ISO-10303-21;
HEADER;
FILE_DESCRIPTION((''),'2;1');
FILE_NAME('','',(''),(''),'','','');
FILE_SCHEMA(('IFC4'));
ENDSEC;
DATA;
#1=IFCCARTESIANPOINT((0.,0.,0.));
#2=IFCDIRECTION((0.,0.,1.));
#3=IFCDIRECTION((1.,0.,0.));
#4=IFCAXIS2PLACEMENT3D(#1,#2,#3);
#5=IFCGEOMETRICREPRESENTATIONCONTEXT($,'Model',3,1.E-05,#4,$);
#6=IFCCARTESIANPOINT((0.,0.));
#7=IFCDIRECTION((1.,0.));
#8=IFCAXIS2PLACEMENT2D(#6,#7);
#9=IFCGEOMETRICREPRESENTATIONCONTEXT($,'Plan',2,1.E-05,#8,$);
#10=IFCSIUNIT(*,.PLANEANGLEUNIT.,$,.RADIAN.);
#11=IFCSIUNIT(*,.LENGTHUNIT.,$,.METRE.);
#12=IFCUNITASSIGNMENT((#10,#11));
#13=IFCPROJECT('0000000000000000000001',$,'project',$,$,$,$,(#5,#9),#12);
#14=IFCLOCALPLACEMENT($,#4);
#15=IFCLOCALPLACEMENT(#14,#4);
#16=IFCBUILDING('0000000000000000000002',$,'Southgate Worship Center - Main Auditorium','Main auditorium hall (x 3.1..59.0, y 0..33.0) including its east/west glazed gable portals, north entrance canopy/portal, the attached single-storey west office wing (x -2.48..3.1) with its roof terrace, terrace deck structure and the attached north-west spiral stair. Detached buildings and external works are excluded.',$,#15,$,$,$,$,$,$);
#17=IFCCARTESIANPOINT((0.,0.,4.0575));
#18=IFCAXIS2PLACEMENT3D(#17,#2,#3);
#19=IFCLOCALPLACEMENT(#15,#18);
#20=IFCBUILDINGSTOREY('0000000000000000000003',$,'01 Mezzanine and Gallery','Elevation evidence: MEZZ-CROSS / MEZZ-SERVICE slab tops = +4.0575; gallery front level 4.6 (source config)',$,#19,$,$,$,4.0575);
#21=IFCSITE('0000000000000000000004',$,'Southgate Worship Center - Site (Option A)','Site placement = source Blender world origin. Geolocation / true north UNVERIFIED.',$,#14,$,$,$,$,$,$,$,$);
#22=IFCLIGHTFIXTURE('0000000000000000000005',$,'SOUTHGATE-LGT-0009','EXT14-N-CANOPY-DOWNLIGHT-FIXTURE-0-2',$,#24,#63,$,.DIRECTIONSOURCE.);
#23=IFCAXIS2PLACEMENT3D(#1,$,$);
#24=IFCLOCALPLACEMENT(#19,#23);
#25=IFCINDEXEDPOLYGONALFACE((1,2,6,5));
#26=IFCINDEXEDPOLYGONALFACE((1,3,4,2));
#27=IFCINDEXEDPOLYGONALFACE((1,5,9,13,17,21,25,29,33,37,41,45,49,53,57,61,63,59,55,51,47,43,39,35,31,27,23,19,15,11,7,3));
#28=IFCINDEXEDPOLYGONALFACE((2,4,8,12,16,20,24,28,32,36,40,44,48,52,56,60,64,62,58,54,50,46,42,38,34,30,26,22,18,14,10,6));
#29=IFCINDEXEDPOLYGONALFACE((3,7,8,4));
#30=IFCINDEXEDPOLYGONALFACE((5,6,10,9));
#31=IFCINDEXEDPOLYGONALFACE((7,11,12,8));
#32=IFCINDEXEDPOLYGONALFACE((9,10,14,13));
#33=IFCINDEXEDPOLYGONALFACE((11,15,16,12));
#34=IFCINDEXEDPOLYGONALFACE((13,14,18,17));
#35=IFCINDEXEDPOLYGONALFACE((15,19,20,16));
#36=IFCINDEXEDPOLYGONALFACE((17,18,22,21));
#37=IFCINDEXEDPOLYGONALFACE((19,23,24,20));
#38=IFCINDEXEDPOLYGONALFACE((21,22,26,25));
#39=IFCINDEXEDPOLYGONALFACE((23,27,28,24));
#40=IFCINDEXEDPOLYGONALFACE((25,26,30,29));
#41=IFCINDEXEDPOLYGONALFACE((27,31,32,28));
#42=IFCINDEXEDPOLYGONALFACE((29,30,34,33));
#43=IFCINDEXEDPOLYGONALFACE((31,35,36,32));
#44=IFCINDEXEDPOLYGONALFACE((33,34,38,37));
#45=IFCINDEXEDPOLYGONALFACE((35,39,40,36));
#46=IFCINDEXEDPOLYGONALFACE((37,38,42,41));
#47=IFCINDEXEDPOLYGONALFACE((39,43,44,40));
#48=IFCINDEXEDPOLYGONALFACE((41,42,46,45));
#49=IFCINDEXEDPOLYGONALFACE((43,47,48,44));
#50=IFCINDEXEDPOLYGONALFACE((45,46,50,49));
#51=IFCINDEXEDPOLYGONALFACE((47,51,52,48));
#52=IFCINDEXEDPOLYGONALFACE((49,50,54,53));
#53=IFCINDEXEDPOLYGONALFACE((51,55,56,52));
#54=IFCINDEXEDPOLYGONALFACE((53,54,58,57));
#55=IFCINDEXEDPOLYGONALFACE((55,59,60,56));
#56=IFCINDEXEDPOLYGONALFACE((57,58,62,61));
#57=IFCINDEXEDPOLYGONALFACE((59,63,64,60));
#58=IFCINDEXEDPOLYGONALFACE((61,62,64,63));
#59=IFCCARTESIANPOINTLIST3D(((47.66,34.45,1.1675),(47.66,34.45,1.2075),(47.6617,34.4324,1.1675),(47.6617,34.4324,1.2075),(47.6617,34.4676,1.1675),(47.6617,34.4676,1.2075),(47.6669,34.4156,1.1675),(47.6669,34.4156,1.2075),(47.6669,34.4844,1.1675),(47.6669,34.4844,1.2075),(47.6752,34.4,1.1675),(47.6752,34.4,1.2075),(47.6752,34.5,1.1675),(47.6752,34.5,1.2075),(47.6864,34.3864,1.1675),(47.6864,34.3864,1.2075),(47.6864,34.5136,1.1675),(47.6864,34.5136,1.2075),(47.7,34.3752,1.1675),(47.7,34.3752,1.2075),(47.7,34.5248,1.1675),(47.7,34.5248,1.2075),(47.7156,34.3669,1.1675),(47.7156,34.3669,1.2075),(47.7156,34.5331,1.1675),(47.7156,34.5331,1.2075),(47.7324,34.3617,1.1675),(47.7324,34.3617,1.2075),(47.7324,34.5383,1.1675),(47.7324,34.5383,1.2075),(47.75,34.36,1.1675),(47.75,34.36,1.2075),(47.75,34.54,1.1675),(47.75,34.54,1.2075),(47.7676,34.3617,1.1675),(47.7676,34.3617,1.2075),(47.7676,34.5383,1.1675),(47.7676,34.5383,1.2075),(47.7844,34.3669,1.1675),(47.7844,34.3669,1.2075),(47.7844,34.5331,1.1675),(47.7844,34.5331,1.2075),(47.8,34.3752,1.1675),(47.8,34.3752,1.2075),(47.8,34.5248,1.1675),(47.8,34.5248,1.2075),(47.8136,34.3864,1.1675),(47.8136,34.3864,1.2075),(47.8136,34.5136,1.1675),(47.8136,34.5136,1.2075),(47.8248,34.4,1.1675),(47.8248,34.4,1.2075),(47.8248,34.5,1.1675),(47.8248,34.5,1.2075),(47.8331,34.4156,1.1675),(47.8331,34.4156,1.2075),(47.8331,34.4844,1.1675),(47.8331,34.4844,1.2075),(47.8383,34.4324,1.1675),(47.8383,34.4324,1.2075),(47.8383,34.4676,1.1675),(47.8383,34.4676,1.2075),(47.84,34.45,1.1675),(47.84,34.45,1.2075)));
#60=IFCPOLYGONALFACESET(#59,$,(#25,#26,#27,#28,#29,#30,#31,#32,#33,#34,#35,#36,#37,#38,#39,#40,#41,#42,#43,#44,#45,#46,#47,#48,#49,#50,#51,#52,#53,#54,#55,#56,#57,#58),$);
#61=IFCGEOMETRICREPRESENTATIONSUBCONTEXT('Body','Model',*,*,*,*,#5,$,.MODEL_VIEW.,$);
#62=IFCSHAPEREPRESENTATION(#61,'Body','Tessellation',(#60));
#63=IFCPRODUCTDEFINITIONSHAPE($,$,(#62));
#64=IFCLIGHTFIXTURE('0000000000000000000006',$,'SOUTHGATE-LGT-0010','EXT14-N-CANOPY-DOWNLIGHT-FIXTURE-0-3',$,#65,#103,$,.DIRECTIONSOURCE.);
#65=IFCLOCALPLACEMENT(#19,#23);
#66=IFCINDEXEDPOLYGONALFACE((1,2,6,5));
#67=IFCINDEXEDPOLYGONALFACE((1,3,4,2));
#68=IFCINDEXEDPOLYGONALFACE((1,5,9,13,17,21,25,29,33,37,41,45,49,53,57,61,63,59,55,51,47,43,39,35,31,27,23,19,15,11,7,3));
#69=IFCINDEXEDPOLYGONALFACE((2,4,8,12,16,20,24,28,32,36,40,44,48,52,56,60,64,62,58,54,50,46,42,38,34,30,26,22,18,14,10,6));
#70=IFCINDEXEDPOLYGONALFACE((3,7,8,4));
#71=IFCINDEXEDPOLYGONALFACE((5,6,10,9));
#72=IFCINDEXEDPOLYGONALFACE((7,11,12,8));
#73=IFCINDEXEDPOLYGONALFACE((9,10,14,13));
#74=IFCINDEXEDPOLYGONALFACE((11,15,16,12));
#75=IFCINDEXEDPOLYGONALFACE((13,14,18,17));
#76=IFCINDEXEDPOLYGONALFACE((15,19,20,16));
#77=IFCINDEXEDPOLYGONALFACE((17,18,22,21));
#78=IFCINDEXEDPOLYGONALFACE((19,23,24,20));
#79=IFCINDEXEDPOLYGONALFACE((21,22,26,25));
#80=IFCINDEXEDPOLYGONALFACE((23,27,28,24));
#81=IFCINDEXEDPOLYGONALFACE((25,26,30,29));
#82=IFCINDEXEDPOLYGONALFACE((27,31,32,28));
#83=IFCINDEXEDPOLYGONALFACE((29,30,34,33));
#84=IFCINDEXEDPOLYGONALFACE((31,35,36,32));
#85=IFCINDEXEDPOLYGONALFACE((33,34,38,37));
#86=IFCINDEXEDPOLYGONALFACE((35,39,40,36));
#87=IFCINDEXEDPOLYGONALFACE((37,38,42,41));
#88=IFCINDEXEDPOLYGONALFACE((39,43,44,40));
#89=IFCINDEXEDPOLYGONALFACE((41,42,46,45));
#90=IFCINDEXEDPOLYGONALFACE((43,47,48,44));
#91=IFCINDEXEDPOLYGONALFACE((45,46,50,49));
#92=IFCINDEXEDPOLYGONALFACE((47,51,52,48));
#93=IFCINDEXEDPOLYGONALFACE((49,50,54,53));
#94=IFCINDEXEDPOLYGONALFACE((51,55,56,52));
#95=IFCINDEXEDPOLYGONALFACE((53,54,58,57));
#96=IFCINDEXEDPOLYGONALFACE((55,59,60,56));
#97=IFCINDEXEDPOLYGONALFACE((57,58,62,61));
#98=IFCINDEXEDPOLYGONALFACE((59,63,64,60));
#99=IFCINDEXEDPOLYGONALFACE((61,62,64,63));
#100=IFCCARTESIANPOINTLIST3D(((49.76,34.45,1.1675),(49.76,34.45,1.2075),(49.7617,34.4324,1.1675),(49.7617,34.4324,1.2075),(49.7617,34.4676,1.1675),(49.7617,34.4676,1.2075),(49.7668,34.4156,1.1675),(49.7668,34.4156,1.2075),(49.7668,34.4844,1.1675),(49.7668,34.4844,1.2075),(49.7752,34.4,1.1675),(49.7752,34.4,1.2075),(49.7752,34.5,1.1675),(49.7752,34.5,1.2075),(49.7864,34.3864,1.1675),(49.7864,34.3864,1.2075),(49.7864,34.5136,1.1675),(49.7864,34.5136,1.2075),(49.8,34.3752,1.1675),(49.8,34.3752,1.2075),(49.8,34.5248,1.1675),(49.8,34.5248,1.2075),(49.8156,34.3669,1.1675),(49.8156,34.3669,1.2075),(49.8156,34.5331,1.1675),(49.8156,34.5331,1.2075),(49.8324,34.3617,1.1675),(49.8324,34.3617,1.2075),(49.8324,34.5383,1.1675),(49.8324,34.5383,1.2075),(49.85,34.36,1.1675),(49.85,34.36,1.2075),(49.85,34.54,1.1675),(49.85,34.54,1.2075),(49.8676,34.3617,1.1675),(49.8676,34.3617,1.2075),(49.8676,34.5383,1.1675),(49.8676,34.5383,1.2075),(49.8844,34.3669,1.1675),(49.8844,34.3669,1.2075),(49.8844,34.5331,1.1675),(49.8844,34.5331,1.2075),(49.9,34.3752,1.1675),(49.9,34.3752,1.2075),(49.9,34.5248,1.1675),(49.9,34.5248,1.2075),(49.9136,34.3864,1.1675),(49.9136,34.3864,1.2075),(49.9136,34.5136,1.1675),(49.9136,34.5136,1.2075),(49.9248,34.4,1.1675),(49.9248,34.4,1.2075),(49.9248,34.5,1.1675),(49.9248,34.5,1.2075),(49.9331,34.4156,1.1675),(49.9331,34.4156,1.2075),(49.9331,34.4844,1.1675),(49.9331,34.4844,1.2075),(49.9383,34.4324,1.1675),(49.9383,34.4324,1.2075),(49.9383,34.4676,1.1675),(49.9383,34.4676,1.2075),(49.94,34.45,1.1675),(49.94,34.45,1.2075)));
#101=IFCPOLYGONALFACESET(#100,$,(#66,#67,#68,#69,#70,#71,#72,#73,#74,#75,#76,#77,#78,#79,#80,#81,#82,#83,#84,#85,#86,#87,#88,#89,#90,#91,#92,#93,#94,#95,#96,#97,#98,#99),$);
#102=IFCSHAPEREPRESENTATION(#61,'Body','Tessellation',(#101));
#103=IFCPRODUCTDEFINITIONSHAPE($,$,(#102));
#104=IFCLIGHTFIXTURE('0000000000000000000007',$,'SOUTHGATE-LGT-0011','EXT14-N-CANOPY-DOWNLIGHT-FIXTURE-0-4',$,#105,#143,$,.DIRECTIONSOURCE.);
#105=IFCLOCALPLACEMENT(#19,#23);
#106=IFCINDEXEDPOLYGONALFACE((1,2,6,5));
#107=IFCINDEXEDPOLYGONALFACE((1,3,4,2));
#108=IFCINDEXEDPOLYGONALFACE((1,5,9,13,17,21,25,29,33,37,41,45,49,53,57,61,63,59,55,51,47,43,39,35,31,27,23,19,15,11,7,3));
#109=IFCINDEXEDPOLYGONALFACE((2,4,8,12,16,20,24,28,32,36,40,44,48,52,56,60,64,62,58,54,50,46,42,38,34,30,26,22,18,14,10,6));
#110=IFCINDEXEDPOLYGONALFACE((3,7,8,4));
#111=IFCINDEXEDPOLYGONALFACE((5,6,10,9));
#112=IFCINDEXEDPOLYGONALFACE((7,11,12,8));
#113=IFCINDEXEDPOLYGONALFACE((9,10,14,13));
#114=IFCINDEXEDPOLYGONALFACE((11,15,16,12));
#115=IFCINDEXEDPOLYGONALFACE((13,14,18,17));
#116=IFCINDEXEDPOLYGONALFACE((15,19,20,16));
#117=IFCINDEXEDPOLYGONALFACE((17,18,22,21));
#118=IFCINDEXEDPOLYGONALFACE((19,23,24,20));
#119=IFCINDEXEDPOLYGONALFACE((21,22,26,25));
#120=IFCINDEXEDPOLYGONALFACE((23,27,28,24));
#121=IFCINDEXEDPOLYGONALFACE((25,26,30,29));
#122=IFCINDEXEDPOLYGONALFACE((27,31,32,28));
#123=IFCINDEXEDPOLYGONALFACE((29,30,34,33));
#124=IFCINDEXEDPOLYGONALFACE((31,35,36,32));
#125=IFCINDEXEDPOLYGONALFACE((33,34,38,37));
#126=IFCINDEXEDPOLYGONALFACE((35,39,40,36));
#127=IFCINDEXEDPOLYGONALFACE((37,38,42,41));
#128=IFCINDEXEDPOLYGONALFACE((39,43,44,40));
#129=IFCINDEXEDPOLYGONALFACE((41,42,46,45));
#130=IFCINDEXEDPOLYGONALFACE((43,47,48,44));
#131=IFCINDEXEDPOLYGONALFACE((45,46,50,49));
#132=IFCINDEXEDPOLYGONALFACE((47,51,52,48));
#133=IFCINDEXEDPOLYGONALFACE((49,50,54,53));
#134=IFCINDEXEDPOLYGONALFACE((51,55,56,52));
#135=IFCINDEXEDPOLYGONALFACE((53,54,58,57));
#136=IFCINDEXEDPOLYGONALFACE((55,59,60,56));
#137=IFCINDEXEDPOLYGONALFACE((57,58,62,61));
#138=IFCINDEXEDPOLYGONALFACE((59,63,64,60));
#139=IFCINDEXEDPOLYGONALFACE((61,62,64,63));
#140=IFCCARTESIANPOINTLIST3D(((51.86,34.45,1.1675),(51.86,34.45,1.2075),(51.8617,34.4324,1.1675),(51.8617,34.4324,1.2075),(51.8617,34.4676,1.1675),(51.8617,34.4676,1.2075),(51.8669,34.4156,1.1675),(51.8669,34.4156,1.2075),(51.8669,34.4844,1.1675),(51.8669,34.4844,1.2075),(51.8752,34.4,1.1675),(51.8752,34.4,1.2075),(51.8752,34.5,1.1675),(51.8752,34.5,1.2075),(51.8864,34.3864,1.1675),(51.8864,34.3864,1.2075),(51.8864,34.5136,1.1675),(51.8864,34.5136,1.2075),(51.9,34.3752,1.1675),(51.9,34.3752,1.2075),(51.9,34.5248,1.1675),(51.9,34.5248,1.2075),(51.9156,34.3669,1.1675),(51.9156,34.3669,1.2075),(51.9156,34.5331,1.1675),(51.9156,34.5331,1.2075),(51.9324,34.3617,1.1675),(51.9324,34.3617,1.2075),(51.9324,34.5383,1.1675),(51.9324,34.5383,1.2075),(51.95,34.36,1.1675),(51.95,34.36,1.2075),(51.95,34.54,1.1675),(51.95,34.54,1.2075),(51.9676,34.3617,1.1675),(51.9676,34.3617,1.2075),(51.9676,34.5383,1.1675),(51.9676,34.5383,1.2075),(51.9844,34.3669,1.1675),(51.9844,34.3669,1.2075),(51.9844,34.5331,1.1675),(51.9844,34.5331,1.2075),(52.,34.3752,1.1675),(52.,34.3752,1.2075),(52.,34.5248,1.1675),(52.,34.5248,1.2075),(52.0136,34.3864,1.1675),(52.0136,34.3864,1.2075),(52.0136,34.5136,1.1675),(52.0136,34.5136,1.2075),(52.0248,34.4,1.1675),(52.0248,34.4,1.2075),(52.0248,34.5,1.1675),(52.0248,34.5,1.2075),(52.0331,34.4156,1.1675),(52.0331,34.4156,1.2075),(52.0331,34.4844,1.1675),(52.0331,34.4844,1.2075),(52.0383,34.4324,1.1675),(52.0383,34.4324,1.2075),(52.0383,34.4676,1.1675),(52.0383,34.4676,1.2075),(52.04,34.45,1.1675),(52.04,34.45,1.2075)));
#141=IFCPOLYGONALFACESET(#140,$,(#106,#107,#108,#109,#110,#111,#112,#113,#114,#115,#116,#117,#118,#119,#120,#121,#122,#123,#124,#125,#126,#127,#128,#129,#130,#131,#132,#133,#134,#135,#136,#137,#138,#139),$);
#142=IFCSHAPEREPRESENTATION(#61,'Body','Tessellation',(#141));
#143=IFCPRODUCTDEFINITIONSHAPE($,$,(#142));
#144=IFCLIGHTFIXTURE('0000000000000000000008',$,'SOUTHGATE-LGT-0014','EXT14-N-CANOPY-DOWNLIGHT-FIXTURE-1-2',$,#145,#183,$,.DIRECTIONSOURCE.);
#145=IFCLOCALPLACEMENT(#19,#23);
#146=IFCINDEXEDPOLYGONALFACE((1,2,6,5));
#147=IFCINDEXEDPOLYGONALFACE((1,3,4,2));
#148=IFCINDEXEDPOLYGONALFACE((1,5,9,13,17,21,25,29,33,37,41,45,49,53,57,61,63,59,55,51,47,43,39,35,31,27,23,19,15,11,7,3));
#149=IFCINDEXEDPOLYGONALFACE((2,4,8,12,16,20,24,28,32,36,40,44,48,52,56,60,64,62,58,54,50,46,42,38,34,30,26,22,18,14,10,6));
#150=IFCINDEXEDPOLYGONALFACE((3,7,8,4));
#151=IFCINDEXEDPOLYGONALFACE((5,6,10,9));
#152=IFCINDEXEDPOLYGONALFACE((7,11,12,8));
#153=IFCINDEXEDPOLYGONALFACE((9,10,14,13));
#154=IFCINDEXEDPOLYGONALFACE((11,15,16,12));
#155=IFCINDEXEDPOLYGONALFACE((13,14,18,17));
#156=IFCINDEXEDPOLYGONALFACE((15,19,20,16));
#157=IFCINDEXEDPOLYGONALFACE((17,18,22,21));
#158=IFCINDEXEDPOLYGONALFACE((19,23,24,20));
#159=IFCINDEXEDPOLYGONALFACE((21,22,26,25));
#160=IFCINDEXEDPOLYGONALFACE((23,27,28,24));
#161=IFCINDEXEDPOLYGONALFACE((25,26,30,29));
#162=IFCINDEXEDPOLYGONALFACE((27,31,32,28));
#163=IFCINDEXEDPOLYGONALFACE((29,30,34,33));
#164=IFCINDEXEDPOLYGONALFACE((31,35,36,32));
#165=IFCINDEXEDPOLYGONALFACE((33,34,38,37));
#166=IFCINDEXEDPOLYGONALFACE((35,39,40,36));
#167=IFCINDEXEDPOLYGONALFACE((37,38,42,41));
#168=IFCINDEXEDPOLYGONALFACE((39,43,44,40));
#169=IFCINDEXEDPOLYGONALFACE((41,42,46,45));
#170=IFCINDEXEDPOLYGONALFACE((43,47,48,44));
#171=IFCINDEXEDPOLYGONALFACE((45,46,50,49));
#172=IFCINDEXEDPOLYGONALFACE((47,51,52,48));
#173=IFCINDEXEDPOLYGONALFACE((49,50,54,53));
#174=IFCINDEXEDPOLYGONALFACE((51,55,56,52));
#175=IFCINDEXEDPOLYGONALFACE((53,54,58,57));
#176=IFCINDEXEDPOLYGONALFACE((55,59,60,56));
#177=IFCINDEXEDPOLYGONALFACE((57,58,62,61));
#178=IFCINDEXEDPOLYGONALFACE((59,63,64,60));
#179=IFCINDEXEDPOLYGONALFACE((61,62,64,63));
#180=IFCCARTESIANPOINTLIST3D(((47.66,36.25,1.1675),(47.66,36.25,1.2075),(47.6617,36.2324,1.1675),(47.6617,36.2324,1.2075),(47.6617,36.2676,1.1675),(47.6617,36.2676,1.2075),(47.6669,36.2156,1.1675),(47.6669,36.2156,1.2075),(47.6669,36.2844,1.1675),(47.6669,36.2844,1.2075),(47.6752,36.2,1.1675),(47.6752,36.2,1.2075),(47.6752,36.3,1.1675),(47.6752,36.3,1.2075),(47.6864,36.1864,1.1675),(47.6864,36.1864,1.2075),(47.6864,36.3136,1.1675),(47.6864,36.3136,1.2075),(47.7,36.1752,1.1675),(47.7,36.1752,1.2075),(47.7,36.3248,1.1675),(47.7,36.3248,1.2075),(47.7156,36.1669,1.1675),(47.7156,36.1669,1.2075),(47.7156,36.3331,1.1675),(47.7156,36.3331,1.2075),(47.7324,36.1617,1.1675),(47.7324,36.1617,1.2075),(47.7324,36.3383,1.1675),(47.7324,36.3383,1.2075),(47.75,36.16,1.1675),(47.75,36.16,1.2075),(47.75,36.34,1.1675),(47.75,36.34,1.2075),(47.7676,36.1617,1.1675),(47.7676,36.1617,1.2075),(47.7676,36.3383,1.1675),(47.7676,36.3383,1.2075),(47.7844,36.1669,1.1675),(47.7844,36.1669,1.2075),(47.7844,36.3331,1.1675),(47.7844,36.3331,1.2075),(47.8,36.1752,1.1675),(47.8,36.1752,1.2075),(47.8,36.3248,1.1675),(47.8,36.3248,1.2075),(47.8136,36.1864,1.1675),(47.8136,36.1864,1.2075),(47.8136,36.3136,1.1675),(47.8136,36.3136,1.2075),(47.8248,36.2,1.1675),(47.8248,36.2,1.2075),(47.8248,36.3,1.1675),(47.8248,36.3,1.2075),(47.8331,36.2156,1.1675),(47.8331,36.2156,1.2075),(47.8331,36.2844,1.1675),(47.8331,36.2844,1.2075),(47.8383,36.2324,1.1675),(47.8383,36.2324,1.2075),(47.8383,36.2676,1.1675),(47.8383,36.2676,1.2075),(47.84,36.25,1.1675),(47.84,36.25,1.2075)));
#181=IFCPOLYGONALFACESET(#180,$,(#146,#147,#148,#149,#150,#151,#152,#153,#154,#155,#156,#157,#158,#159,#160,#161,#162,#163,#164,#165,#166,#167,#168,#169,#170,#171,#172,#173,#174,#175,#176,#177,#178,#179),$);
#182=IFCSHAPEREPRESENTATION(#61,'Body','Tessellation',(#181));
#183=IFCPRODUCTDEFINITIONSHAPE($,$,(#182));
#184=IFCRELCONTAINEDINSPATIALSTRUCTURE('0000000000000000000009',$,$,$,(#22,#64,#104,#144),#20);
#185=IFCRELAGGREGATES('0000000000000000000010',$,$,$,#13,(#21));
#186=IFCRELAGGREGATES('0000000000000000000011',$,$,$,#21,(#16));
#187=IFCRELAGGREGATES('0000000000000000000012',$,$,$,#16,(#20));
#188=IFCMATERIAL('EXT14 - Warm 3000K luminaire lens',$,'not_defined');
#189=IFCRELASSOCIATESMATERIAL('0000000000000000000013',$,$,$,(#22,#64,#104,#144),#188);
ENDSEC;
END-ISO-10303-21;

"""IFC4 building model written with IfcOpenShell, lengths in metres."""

from ifc_helpers import new_model, si_unit, frame, origin_with_axes, origin_2d_with_axis, place, context, subcontext, project, spatial, indexed_curve, outline, extrude, material, element, save


model = new_model("IFC4")

# Units and contexts
model_context = context("Model", 3, precision=1e-05, world=origin_with_axes())
plan_context = context("Plan", 2, precision=1e-05, world=origin_2d_with_axis())
body_context = subcontext(model_context, "Body", "Model", "MODEL_VIEW")
ifc_project = project(units=[si_unit("PLANEANGLEUNIT", "RADIAN"), si_unit("LENGTHUNIT", "METRE")], contexts=[model_context, plan_context])

# Site, building, storey
site_placement = place(None, origin_with_axes())
site = spatial("IfcSite", under=ifc_project, at=site_placement, Name="Southgate Worship Center - Site (Option A)", Description="Site placement = source Blender world origin. Geolocation / true north UNVERIFIED.")
building_placement = place(site_placement, origin_with_axes())
building = spatial("IfcBuilding", under=site, at=building_placement, Name="Southgate Worship Center - Main Auditorium", Description="Main auditorium hall (x 3.1..59.0, y 0..33.0) including its east/west glazed gable portals, north entrance canopy/portal, the attached single-storey west office wing (x -2.48..3.1) with its roof terrace, terrace deck structure and the attached north-west spiral stair. Detached buildings and external works are excluded.")
storey_placement = place(building_placement, frame((0.0, 0.0, 4.0575), z_axis=(0.0, 0.0, 1.0), x_axis=(1.0, 0.0, 0.0)))
storey = spatial("IfcBuildingStorey", under=building, at=storey_placement, Name="01 Mezzanine and Gallery", Description="Elevation evidence: MEZZ-CROSS / MEZZ-SERVICE slab tops = +4.0575; gallery front level 4.6 (source config)", Elevation=4.0575)

# Light fixtures
ifc_material_1 = material(Name="EXT14 - Warm 3000K luminaire lens", Category="not_defined")
light_fixture_1_placement = place(storey_placement, frame((47.66, 34.36, 1.1675), z_axis=(0.0, 0.0, 1.0), x_axis=(1.0, 0.0, 0.0)))
element("IfcLightFixture", 1, at=light_fixture_1_placement, inside=storey, material=ifc_material_1, Name="SOUTHGATE-LGT-0009", Description="EXT14-N-CANOPY-DOWNLIGHT-FIXTURE-0-2", PredefinedType="DIRECTIONSOURCE", context=body_context, shape_type="SweptSolid", body=[
    extrude(outline(indexed_curve([(0.0, 0.0), (-0.0083, -0.0156), (-0.0134, -0.0324), (-0.0152, -0.05), (-0.0134, -0.0676), (-0.0083, -0.0844), (0.0, -0.1), (0.0112, -0.1136), (0.0248, -0.1248), (0.0404, -0.1332), (0.0573, -0.1383), (0.0748, -0.14), (0.0924, -0.1383), (0.1093, -0.1332), (0.1248, -0.1248), (0.1385, -0.1136), (0.1497, -0.1), (0.158, -0.0844), (0.1631, -0.0676), (0.1648, -0.05), (0.1631, -0.0324), (0.158, -0.0156), (0.1497, 0.0), (0.1385, 0.0136), (0.1248, 0.0248), (0.1093, 0.0331), (0.0924, 0.0383), (0.0748, 0.04), (0.0573, 0.0383), (0.0404, 0.0331), (0.0248, 0.0248), (0.0112, 0.0136), (0.0, 0.0)], self_intersect=False)), frame((0.0152, 0.14, 0.0), z_axis=(0.0, 0.0, 1.0), x_axis=(1.0, 0.0, 0.0)), (0.0, 0.0, 1.0), 0.04),
])
light_fixture_2_placement = place(storey_placement, frame((49.76, 34.36, 1.1675), z_axis=(0.0, 0.0, 1.0), x_axis=(1.0, 0.0, 0.0)))
element("IfcLightFixture", 2, at=light_fixture_2_placement, inside=storey, material=ifc_material_1, Name="SOUTHGATE-LGT-0010", Description="EXT14-N-CANOPY-DOWNLIGHT-FIXTURE-0-3", PredefinedType="DIRECTIONSOURCE", context=body_context, shape_type="SweptSolid", body=[
    extrude(outline(indexed_curve([(0.0, 0.0), (-0.0083, -0.0156), (-0.0134, -0.0324), (-0.0152, -0.05), (-0.0134, -0.0676), (-0.0083, -0.0844), (0.0, -0.1), (0.0112, -0.1136), (0.0248, -0.1248), (0.0404, -0.1332), (0.0573, -0.1383), (0.0748, -0.14), (0.0924, -0.1383), (0.1093, -0.1332), (0.1248, -0.1248), (0.1385, -0.1136), (0.1497, -0.1), (0.158, -0.0844), (0.1631, -0.0676), (0.1648, -0.05), (0.1631, -0.0324), (0.158, -0.0156), (0.1497, 0.0), (0.1385, 0.0136), (0.1248, 0.0248), (0.1093, 0.0331), (0.0924, 0.0383), (0.0748, 0.04), (0.0573, 0.0383), (0.0404, 0.0331), (0.0248, 0.0248), (0.0112, 0.0136), (0.0, 0.0)], self_intersect=False)), frame((0.0152, 0.14, 0.0), z_axis=(0.0, 0.0, 1.0), x_axis=(1.0, 0.0, 0.0)), (0.0, 0.0, 1.0), 0.04),
])
light_fixture_3_placement = place(storey_placement, frame((51.86, 34.36, 1.1675), z_axis=(0.0, 0.0, 1.0), x_axis=(1.0, 0.0, 0.0)))
element("IfcLightFixture", 3, at=light_fixture_3_placement, inside=storey, material=ifc_material_1, Name="SOUTHGATE-LGT-0011", Description="EXT14-N-CANOPY-DOWNLIGHT-FIXTURE-0-4", PredefinedType="DIRECTIONSOURCE", context=body_context, shape_type="SweptSolid", body=[
    extrude(outline(indexed_curve([(0.0, 0.0), (-0.0083, -0.0156), (-0.0134, -0.0324), (-0.0152, -0.05), (-0.0134, -0.0676), (-0.0083, -0.0844), (0.0, -0.1), (0.0112, -0.1136), (0.0248, -0.1248), (0.0404, -0.1332), (0.0573, -0.1383), (0.0748, -0.14), (0.0924, -0.1383), (0.1093, -0.1332), (0.1248, -0.1248), (0.1385, -0.1136), (0.1497, -0.1), (0.158, -0.0844), (0.1631, -0.0676), (0.1648, -0.05), (0.1631, -0.0324), (0.158, -0.0156), (0.1497, 0.0), (0.1385, 0.0136), (0.1248, 0.0248), (0.1093, 0.0331), (0.0924, 0.0383), (0.0748, 0.04), (0.0573, 0.0383), (0.0404, 0.0331), (0.0248, 0.0248), (0.0112, 0.0136), (0.0, 0.0)], self_intersect=False)), frame((0.0152, 0.14, 0.0), z_axis=(0.0, 0.0, 1.0), x_axis=(1.0, 0.0, 0.0)), (0.0, 0.0, 1.0), 0.04),
])
light_fixture_4_placement = place(storey_placement, frame((47.66, 36.16, 1.1675), z_axis=(0.0, 0.0, 1.0), x_axis=(1.0, 0.0, 0.0)))
element("IfcLightFixture", 4, at=light_fixture_4_placement, inside=storey, material=ifc_material_1, Name="SOUTHGATE-LGT-0014", Description="EXT14-N-CANOPY-DOWNLIGHT-FIXTURE-1-2", PredefinedType="DIRECTIONSOURCE", context=body_context, shape_type="SweptSolid", body=[
    extrude(outline(indexed_curve([(0.0, 0.0), (-0.0083, -0.0156), (-0.0134, -0.0324), (-0.0152, -0.05), (-0.0134, -0.0676), (-0.0083, -0.0844), (0.0, -0.1), (0.0112, -0.1136), (0.0248, -0.1248), (0.0404, -0.1332), (0.0573, -0.1383), (0.0748, -0.14), (0.0924, -0.1383), (0.1093, -0.1332), (0.1248, -0.1248), (0.1385, -0.1136), (0.1497, -0.1), (0.158, -0.0844), (0.1631, -0.0676), (0.1648, -0.05), (0.1631, -0.0324), (0.158, -0.0156), (0.1497, 0.0), (0.1385, 0.0136), (0.1248, 0.0248), (0.1093, 0.0331), (0.0924, 0.0383), (0.0748, 0.04), (0.0573, 0.0383), (0.0404, 0.0331), (0.0248, 0.0248), (0.0112, 0.0136), (0.0, 0.0)], self_intersect=False)), frame((0.0152, 0.14, 0.0), z_axis=(0.0, 0.0, 1.0), x_axis=(1.0, 0.0, 0.0)), (0.0, 0.0, 1.0), 0.04),
])

save(model, "model.ifc")
